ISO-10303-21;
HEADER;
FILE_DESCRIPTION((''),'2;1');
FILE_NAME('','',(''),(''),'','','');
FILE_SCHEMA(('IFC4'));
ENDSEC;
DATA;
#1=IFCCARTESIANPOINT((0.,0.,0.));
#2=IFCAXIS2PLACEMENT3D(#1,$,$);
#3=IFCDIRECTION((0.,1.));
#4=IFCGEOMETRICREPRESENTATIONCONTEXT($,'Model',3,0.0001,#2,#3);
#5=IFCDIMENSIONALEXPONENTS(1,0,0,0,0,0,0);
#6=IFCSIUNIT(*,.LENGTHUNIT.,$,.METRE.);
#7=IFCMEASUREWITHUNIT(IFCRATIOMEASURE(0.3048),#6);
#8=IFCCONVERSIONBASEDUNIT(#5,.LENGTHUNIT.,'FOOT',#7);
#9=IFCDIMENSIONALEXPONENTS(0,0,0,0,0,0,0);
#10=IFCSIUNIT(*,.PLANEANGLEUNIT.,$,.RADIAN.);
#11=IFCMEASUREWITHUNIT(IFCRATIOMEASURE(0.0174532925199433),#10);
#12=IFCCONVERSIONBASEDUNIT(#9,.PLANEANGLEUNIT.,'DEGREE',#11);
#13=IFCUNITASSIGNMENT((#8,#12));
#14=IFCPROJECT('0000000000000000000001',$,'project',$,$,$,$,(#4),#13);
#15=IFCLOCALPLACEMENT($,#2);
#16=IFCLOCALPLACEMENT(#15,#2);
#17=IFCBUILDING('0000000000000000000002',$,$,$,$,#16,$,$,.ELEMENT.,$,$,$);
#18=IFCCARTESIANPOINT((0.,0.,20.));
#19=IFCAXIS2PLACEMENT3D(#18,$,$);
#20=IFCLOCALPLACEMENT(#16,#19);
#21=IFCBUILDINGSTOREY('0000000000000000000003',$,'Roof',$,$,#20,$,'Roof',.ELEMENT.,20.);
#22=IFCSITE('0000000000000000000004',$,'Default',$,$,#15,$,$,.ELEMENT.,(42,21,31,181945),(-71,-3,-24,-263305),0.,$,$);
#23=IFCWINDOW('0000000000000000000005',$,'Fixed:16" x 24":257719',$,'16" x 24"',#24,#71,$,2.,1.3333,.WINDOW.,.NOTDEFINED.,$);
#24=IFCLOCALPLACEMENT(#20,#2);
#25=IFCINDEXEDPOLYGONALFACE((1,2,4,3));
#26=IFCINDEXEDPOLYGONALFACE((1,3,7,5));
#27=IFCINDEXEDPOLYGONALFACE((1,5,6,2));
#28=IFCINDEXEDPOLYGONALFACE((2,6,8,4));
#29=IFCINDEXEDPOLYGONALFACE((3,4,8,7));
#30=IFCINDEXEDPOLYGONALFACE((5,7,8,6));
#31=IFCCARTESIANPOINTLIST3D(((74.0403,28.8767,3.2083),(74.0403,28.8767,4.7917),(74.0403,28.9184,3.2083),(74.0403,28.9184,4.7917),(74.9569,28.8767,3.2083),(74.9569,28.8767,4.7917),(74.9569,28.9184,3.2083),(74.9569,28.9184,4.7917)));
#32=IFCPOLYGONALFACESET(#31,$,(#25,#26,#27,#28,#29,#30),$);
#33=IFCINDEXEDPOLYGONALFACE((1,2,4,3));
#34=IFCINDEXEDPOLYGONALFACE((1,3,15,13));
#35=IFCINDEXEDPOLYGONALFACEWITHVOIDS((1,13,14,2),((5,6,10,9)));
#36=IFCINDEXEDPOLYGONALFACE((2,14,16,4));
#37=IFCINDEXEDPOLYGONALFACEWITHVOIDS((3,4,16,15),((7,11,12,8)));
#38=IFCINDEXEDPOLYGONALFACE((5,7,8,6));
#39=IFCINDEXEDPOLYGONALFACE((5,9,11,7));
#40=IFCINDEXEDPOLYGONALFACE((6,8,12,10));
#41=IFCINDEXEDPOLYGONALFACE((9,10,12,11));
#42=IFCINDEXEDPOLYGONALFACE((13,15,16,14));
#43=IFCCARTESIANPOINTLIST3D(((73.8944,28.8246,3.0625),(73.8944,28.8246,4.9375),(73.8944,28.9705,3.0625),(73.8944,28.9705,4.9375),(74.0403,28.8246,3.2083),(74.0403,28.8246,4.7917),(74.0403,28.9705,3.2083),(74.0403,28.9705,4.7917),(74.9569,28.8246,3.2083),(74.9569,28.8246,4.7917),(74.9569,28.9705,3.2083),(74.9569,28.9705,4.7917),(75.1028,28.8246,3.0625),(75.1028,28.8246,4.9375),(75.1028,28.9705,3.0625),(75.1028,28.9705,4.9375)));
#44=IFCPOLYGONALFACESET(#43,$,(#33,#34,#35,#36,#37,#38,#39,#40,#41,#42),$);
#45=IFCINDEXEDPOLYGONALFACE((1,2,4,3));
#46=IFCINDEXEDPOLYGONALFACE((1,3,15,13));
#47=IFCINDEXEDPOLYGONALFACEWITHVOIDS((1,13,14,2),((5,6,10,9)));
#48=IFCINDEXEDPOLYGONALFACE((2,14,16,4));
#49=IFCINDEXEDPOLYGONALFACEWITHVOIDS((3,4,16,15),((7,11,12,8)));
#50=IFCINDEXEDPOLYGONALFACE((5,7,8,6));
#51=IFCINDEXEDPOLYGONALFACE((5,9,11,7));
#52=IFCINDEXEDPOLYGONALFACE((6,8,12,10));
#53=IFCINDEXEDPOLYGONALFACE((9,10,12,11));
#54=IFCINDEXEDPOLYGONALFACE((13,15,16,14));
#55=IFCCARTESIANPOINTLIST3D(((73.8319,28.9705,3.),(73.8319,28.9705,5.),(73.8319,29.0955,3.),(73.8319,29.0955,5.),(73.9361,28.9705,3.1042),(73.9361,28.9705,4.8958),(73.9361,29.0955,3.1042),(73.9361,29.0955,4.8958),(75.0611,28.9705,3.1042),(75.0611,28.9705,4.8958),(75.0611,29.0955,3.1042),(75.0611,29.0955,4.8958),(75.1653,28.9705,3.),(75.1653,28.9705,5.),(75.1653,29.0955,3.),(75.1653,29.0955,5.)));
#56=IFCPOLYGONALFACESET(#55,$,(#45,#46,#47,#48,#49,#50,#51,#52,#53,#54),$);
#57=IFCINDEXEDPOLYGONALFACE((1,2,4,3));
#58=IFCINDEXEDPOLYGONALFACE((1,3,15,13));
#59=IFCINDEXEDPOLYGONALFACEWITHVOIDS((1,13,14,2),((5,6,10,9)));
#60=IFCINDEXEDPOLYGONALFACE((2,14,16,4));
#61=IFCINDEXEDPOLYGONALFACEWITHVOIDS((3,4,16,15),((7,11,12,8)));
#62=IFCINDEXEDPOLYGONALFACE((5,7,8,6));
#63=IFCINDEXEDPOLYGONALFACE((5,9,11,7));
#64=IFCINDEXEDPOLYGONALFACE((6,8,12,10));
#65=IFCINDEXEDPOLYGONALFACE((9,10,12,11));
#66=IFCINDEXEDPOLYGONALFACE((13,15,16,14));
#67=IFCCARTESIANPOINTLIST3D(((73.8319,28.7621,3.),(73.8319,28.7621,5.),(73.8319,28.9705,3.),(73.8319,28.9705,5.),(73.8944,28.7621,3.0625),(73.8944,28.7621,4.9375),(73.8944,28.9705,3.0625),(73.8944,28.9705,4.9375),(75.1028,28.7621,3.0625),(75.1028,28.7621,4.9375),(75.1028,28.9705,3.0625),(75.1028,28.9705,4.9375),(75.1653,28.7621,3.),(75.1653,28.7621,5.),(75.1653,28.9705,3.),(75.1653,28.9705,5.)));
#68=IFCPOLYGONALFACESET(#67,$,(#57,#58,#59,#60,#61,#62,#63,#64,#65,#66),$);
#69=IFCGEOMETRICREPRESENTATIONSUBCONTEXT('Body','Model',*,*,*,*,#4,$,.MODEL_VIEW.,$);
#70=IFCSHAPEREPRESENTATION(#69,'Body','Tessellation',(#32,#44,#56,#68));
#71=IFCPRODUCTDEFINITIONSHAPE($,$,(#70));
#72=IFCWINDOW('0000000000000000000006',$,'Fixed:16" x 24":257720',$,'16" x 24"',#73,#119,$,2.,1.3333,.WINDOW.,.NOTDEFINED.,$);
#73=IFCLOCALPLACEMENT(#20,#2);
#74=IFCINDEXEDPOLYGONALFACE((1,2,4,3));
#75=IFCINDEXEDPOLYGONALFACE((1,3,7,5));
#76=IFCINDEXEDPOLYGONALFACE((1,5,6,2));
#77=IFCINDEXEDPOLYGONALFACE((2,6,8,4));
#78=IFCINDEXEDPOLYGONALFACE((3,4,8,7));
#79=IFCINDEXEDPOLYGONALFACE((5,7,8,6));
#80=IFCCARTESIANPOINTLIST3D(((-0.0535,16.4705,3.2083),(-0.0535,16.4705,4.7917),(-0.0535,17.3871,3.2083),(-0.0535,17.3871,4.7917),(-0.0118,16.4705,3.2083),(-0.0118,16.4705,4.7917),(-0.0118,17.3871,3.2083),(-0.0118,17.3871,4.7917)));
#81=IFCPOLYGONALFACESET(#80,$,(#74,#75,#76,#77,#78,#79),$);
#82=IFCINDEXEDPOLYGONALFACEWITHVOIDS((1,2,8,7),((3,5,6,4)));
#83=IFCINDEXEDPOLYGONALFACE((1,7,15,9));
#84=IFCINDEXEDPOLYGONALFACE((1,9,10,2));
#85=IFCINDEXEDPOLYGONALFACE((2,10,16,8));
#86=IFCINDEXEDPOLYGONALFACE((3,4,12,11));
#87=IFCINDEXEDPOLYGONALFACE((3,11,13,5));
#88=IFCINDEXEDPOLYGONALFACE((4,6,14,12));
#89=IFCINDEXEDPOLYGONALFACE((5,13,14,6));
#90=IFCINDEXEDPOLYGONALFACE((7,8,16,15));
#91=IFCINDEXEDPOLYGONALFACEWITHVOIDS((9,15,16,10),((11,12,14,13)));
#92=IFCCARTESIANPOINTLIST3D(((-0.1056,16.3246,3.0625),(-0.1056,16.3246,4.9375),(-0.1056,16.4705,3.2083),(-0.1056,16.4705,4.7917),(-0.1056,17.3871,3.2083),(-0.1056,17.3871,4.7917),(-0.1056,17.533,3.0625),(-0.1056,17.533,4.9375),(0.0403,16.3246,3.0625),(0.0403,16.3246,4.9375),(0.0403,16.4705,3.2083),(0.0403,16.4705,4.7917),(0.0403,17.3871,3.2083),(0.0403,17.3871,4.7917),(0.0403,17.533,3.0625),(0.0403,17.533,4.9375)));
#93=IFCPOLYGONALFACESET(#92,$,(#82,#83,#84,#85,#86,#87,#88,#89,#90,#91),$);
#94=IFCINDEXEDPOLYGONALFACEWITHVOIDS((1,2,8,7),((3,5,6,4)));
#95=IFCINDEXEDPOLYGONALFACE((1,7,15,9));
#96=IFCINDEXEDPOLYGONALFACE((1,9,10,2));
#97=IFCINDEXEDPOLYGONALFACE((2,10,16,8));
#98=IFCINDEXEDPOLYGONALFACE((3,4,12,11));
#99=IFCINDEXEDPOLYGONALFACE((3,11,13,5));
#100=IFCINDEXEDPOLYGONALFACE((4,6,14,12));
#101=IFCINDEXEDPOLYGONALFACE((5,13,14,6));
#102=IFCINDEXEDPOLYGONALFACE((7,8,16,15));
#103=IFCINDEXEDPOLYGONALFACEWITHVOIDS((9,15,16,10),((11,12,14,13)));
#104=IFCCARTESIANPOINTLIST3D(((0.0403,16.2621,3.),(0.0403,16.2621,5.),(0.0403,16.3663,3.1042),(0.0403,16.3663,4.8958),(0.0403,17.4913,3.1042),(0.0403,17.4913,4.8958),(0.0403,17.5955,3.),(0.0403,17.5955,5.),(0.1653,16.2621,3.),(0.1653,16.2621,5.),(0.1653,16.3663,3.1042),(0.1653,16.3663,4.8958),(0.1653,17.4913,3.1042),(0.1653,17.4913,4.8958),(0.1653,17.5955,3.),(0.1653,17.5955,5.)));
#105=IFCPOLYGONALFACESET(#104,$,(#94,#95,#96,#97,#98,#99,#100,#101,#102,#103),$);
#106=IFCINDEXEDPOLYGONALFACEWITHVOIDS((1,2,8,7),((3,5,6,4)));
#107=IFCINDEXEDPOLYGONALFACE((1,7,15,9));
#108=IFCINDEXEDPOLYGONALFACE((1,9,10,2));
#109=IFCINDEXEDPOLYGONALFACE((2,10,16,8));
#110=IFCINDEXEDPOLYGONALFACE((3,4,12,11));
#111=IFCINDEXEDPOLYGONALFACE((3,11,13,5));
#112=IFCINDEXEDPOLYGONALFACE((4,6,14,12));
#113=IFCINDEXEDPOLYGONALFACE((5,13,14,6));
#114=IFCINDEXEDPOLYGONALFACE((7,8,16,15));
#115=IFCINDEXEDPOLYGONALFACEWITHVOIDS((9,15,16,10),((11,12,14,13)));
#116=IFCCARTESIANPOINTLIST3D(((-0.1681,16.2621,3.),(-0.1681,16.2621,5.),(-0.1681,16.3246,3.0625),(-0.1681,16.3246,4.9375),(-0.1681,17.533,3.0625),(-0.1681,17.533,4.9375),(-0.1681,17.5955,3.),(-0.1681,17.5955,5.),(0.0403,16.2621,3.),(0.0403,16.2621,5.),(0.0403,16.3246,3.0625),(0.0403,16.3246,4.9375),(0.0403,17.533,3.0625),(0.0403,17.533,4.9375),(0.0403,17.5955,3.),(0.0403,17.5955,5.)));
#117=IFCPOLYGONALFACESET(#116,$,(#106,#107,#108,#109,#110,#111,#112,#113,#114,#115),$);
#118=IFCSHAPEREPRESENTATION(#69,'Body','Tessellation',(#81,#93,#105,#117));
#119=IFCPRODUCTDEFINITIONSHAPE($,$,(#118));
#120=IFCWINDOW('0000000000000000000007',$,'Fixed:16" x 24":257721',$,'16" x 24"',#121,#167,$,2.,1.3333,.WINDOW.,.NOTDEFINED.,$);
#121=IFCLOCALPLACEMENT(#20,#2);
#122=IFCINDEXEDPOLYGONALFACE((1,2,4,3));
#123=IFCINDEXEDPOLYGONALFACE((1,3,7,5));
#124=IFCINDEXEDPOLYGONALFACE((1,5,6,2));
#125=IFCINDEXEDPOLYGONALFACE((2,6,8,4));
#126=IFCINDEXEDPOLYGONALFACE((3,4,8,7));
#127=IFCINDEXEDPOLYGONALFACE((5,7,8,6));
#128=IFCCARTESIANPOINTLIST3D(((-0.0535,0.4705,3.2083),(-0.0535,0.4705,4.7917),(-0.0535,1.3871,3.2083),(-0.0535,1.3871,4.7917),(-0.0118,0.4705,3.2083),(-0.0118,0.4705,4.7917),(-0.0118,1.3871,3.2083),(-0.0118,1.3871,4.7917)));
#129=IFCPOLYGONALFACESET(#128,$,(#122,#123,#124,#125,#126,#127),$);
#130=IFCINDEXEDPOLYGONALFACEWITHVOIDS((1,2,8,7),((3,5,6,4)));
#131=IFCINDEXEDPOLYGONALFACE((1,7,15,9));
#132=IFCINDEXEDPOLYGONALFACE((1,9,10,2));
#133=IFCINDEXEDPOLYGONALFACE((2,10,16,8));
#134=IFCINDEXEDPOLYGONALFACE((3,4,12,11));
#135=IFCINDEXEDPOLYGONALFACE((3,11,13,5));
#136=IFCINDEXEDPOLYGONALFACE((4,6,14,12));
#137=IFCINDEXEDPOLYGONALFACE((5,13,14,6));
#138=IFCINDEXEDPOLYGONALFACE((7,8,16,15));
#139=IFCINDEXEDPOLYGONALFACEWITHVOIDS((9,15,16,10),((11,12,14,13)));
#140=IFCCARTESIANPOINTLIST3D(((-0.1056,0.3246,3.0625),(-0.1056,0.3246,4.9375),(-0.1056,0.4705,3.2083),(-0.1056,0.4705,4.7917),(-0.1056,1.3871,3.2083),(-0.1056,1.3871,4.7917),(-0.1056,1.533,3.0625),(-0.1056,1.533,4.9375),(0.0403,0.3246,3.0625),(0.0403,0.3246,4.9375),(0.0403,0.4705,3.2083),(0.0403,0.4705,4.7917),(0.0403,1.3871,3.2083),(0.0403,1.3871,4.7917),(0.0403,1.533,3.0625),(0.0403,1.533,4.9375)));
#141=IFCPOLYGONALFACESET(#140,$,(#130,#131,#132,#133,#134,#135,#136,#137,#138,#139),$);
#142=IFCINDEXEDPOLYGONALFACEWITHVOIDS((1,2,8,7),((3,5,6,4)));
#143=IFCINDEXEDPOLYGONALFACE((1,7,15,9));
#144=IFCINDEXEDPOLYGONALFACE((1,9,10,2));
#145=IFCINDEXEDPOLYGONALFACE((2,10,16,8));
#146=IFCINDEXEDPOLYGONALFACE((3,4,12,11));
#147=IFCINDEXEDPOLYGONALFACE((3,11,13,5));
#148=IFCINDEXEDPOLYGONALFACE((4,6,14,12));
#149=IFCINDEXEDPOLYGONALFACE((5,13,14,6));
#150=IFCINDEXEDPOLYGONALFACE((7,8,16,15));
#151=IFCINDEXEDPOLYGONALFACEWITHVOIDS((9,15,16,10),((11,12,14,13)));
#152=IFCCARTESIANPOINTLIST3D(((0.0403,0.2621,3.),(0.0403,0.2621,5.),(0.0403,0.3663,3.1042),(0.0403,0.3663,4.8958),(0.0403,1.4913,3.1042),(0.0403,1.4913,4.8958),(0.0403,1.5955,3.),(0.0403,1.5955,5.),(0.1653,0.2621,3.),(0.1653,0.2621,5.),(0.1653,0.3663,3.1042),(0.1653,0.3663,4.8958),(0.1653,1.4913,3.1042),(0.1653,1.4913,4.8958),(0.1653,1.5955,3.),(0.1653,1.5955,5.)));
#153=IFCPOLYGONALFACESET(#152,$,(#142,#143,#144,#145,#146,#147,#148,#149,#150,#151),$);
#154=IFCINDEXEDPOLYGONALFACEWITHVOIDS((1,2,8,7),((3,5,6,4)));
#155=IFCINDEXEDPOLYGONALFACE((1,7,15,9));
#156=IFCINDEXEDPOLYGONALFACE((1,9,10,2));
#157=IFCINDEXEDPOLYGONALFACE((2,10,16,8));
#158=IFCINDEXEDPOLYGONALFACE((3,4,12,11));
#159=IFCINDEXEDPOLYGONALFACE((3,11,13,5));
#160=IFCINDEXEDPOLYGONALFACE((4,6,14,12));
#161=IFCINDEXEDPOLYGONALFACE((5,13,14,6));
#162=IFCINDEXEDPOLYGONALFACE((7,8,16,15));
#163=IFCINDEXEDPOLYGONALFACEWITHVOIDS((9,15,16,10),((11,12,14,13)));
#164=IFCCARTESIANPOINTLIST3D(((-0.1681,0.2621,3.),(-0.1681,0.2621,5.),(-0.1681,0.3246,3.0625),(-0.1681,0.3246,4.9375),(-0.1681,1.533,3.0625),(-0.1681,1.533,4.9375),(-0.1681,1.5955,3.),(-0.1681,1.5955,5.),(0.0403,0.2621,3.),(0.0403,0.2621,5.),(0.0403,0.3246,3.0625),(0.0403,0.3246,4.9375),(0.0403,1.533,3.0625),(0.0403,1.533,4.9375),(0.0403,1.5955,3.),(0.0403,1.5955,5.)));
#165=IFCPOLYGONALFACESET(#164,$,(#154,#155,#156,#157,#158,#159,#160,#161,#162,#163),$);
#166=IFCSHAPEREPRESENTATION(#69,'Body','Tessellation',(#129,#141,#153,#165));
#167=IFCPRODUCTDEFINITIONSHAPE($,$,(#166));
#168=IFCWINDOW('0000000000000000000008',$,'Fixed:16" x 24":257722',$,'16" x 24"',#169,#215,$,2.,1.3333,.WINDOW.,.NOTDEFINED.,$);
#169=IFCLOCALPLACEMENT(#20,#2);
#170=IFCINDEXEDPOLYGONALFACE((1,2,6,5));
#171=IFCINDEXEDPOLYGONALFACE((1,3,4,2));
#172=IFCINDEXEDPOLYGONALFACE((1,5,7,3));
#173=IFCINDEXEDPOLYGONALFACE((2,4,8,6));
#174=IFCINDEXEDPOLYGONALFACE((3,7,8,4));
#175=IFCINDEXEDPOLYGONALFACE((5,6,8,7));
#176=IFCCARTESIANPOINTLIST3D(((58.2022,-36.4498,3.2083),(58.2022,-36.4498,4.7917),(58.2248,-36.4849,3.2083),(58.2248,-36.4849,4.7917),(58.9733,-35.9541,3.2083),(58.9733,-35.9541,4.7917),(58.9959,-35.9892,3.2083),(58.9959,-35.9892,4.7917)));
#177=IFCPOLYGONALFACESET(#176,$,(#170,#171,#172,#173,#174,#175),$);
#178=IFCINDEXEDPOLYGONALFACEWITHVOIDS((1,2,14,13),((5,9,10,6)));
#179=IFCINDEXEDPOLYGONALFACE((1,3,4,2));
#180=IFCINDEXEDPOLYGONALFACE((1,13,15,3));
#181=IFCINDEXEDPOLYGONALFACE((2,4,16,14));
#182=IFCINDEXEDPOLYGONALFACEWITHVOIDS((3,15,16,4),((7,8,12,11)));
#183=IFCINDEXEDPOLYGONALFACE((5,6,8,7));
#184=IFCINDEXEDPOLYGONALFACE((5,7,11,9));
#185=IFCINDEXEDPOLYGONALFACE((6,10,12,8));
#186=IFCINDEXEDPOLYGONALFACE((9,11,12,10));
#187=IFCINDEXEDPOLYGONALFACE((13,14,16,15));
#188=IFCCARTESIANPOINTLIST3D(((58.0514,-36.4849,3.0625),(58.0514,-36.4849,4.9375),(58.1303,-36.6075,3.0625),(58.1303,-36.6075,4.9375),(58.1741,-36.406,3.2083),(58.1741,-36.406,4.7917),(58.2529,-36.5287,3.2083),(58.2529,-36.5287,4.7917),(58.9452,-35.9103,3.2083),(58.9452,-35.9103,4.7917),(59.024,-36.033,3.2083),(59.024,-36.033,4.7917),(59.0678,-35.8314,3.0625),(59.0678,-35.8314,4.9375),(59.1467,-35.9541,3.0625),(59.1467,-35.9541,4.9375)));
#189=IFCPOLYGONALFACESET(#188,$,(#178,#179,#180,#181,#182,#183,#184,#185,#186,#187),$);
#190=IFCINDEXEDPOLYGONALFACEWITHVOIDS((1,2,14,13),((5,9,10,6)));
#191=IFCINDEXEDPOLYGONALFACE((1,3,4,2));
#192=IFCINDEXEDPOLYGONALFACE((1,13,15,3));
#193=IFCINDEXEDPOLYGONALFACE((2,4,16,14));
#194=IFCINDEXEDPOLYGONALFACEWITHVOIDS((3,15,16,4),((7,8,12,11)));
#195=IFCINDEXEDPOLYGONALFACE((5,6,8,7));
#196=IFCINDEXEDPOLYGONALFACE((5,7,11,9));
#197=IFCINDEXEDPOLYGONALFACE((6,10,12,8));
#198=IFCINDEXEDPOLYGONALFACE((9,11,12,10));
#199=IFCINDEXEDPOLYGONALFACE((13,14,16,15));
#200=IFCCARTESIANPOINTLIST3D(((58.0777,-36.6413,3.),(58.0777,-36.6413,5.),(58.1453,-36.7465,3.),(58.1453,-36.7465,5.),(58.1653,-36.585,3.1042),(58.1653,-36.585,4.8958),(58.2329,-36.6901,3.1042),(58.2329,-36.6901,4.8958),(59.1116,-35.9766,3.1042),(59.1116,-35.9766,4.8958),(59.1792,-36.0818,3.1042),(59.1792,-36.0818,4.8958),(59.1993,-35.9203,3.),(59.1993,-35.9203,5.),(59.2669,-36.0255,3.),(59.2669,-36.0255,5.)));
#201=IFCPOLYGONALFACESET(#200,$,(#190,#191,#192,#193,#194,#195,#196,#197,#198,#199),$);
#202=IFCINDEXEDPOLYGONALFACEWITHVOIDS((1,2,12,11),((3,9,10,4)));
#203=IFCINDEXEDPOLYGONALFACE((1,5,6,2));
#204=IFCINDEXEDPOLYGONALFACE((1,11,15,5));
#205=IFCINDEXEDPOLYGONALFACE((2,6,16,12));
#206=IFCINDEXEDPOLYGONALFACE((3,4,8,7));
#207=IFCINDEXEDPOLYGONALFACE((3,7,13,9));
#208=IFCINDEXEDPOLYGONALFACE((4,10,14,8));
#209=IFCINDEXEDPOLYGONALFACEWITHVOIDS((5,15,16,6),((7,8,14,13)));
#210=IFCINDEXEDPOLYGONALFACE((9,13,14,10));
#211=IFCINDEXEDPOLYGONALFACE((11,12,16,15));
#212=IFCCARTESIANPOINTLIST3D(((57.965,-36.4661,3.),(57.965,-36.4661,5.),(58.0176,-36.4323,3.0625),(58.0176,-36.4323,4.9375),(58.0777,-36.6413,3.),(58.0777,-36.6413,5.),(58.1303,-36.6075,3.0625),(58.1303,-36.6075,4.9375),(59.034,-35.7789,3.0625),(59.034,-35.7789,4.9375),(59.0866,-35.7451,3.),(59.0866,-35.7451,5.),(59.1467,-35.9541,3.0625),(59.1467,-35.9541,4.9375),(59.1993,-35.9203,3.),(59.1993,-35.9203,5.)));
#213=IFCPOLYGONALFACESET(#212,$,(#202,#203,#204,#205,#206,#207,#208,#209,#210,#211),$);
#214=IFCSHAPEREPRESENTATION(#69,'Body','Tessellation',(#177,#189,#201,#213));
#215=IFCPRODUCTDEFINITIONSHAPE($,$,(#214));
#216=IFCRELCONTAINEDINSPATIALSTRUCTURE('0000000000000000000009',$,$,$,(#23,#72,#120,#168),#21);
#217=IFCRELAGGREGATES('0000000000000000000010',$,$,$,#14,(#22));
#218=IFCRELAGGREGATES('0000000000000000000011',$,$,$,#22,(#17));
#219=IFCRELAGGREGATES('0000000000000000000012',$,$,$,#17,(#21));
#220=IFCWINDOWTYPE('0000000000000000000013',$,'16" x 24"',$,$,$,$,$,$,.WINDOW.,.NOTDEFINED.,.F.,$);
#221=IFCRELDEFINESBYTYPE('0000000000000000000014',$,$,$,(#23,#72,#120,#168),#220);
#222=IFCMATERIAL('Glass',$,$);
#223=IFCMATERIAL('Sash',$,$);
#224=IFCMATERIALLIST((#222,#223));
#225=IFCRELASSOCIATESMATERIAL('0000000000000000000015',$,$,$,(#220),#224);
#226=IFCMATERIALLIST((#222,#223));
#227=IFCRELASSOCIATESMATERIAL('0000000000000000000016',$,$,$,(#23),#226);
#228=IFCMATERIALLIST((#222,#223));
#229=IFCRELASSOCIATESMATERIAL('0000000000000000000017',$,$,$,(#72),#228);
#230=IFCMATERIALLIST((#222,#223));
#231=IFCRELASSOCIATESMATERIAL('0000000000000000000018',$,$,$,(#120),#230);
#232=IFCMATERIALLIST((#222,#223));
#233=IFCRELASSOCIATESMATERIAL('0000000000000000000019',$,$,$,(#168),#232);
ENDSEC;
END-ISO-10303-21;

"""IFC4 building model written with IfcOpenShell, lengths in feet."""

from ifc_helpers import new_model, entity, si_unit, converted_unit, direction, frame, origin, origin_2d_with_axis, place, context, subcontext, project, spatial, polyline, rectangle, outline, extrude, source, transform, mapped, material, material_list, type_object, type_shapes, element, save


model = new_model("IFC4")

# Units and contexts
model_context = context("Model", 3, precision=0.0001, world=origin(), true_north=direction((0.0, 1.0)))
body_context = subcontext(model_context, "Body", "Model", "MODEL_VIEW")
ifc_project = project(units=[converted_unit("LENGTHUNIT", "FOOT", entity("IfcRatioMeasure", 0.3048), si_unit("LENGTHUNIT", "METRE"), dimensions=[1, 0, 0, 0, 0, 0, 0]), converted_unit("PLANEANGLEUNIT", "DEGREE", entity("IfcRatioMeasure", 0.0174532925199433), si_unit("PLANEANGLEUNIT", "RADIAN"), dimensions=[0, 0, 0, 0, 0, 0, 0])], contexts=[model_context])

# Site, building, storey
site_placement = place(None, origin())
site = spatial("IfcSite", under=ifc_project, at=site_placement, Name="Default", CompositionType="ELEMENT", RefLatitude=(42, 21, 31, 181945), RefLongitude=(-71, -3, -24, -263305), RefElevation=0.0)
building_placement = place(site_placement, origin())
building = spatial("IfcBuilding", under=site, at=building_placement, CompositionType="ELEMENT")
storey_placement = place(building_placement, frame((0.0, 0.0, 20.0)))
storey = spatial("IfcBuildingStorey", under=building, at=storey_placement, Name="Roof", LongName="Roof", CompositionType="ELEMENT", Elevation=20.0)

# Windows
ifc_material_1 = material(Name="Glass")
ifc_material_2 = material(Name="Sash")
ifc_material_list_1 = material_list([ifc_material_1, ifc_material_2])
window_type = type_object("IfcWindowType", Name="16\" x 24\"", ParameterTakesPrecedence=False, PartitioningType="NOTDEFINED", PredefinedType="WINDOW", material=ifc_material_list_1)
shared_shape_1 = source(origin(), body_context, "Body", "SweptSolid", [
    extrude(rectangle(XDim=0.0417, YDim=0.9167, at=origin_2d_with_axis()), frame((0.6667, 0.1979, 0.2083), z_axis=(0.0, 0.0, 1.0), x_axis=(0.0, 1.0, 0.0)), (0.0, 0.0, 1.0), 1.5833),
    extrude(outline(polyline([(-0.6042, -0.9375), (0.6042, -0.9375), (0.6042, 0.9375), (-0.6042, 0.9375), (-0.6042, -0.9375)]), holes=[polyline([(-0.4583, -0.7917), (-0.4583, 0.7917), (0.4583, 0.7917), (0.4583, -0.7917), (-0.4583, -0.7917)])]), frame((0.6667, 0.125, 1.0), z_axis=(0.0, 1.0, 0.0), x_axis=(1.0, 0.0, 0.0)), (0.0, 0.0, 1.0), 0.1458),
    extrude(outline(polyline([(-0.6667, -1.0), (0.6667, -1.0), (0.6667, 1.0), (-0.6667, 1.0), (-0.6667, -1.0)]), holes=[polyline([(-0.5625, -0.8958), (-0.5625, 0.8958), (0.5625, 0.8958), (0.5625, -0.8958), (-0.5625, -0.8958)])]), frame((0.6667, 0.0, 1.0), z_axis=(0.0, 1.0, 0.0), x_axis=(1.0, 0.0, 0.0)), (0.0, 0.0, 1.0), 0.125),
    extrude(outline(polyline([(-1.0, -0.6667), (1.0, -0.6667), (1.0, 0.6667), (-1.0, 0.6667), (-1.0, -0.6667)]), holes=[polyline([(-0.9375, -0.6042), (-0.9375, 0.6042), (0.9375, 0.6042), (0.9375, -0.6042), (-0.9375, -0.6042)])]), frame((0.6667, 0.125, 1.0), z_axis=(0.0, 1.0, 0.0), x_axis=(0.0, 0.0, -1.0)), (0.0, 0.0, 1.0), 0.2083),
])
type_shapes(window_type, [shared_shape_1])
placement_1 = place(building_placement, frame((0.0, 0.0, 10.0)))
placement_2 = place(placement_1, frame((-0.1681, 28.9288, 0.0)))
ifc_material_list_2 = material_list([ifc_material_1, ifc_material_2])
placement_3 = place(placement_2, frame((75.3333, 0.1667, 13.0)))
window_1_placement = place(placement_3, frame((0.0, 0.0, 0.0), z_axis=(0.0, 0.0, 1.0), x_axis=(-1.0, 0.0, 0.0)))
element("IfcWindow", 1, at=window_1_placement, inside=storey, type_object=window_type, material=ifc_material_list_2, Name="Fixed:16\" x 24\":257719", ObjectType="16\" x 24\"", OverallHeight=2.0, OverallWidth=1.3333, PartitioningType="NOTDEFINED", PredefinedType="WINDOW", context=body_context, shape_type="MappedRepresentation", body=[
    mapped(shared_shape_1, transform((0.0, 0.0, 0.0), scale=1.0)),
])
ifc_material_list_3 = material_list([ifc_material_1, ifc_material_2])
placement_4 = place(placement_1, frame((-0.0014, -6.9045, 0.0), z_axis=(0.0, 0.0, 1.0), x_axis=(0.0, 1.0, 0.0)))
placement_5 = place(placement_4, frame((23.1667, -0.1667, 13.0)))
window_2_placement = place(placement_5, origin())
element("IfcWindow", 2, at=window_2_placement, inside=storey, type_object=window_type, material=ifc_material_list_3, Name="Fixed:16\" x 24\":257720", ObjectType="16\" x 24\"", OverallHeight=2.0, OverallWidth=1.3333, PartitioningType="NOTDEFINED", PredefinedType="WINDOW", context=body_context, shape_type="MappedRepresentation", body=[
    mapped(shared_shape_1, transform((0.0, 0.0, 0.0), scale=1.0)),
])
ifc_material_list_4 = material_list([ifc_material_1, ifc_material_2])
placement_6 = place(placement_4, frame((7.1667, -0.1667, 13.0)))
window_3_placement = place(placement_6, origin())
element("IfcWindow", 3, at=window_3_placement, inside=storey, type_object=window_type, material=ifc_material_list_4, Name="Fixed:16\" x 24\":257721", ObjectType="16\" x 24\"", OverallHeight=2.0, OverallWidth=1.3333, PartitioningType="NOTDEFINED", PredefinedType="WINDOW", context=body_context, shape_type="MappedRepresentation", body=[
    mapped(shared_shape_1, transform((0.0, 0.0, 0.0), scale=1.0)),
])
ifc_material_list_5 = material_list([ifc_material_1, ifc_material_2])
placement_7 = place(placement_1, frame((103.9574, -7.0977, 0.0), z_axis=(0.0, 0.0, 1.0), x_axis=(-0.841178, -0.540758, 0.0)))
placement_8 = place(placement_7, frame((54.569, 0.1667, 13.0)))
window_4_placement = place(placement_8, frame((0.0, 0.0, 0.0), z_axis=(0.0, 0.0, 1.0), x_axis=(-1.0, 0.0, 0.0)))
element("IfcWindow", 4, at=window_4_placement, inside=storey, type_object=window_type, material=ifc_material_list_5, Name="Fixed:16\" x 24\":257722", ObjectType="16\" x 24\"", OverallHeight=2.0, OverallWidth=1.3333, PartitioningType="NOTDEFINED", PredefinedType="WINDOW", context=body_context, shape_type="MappedRepresentation", body=[
    mapped(shared_shape_1, transform((0.0, 0.0, 0.0), scale=1.0)),
])

save(model, "model.ifc")
